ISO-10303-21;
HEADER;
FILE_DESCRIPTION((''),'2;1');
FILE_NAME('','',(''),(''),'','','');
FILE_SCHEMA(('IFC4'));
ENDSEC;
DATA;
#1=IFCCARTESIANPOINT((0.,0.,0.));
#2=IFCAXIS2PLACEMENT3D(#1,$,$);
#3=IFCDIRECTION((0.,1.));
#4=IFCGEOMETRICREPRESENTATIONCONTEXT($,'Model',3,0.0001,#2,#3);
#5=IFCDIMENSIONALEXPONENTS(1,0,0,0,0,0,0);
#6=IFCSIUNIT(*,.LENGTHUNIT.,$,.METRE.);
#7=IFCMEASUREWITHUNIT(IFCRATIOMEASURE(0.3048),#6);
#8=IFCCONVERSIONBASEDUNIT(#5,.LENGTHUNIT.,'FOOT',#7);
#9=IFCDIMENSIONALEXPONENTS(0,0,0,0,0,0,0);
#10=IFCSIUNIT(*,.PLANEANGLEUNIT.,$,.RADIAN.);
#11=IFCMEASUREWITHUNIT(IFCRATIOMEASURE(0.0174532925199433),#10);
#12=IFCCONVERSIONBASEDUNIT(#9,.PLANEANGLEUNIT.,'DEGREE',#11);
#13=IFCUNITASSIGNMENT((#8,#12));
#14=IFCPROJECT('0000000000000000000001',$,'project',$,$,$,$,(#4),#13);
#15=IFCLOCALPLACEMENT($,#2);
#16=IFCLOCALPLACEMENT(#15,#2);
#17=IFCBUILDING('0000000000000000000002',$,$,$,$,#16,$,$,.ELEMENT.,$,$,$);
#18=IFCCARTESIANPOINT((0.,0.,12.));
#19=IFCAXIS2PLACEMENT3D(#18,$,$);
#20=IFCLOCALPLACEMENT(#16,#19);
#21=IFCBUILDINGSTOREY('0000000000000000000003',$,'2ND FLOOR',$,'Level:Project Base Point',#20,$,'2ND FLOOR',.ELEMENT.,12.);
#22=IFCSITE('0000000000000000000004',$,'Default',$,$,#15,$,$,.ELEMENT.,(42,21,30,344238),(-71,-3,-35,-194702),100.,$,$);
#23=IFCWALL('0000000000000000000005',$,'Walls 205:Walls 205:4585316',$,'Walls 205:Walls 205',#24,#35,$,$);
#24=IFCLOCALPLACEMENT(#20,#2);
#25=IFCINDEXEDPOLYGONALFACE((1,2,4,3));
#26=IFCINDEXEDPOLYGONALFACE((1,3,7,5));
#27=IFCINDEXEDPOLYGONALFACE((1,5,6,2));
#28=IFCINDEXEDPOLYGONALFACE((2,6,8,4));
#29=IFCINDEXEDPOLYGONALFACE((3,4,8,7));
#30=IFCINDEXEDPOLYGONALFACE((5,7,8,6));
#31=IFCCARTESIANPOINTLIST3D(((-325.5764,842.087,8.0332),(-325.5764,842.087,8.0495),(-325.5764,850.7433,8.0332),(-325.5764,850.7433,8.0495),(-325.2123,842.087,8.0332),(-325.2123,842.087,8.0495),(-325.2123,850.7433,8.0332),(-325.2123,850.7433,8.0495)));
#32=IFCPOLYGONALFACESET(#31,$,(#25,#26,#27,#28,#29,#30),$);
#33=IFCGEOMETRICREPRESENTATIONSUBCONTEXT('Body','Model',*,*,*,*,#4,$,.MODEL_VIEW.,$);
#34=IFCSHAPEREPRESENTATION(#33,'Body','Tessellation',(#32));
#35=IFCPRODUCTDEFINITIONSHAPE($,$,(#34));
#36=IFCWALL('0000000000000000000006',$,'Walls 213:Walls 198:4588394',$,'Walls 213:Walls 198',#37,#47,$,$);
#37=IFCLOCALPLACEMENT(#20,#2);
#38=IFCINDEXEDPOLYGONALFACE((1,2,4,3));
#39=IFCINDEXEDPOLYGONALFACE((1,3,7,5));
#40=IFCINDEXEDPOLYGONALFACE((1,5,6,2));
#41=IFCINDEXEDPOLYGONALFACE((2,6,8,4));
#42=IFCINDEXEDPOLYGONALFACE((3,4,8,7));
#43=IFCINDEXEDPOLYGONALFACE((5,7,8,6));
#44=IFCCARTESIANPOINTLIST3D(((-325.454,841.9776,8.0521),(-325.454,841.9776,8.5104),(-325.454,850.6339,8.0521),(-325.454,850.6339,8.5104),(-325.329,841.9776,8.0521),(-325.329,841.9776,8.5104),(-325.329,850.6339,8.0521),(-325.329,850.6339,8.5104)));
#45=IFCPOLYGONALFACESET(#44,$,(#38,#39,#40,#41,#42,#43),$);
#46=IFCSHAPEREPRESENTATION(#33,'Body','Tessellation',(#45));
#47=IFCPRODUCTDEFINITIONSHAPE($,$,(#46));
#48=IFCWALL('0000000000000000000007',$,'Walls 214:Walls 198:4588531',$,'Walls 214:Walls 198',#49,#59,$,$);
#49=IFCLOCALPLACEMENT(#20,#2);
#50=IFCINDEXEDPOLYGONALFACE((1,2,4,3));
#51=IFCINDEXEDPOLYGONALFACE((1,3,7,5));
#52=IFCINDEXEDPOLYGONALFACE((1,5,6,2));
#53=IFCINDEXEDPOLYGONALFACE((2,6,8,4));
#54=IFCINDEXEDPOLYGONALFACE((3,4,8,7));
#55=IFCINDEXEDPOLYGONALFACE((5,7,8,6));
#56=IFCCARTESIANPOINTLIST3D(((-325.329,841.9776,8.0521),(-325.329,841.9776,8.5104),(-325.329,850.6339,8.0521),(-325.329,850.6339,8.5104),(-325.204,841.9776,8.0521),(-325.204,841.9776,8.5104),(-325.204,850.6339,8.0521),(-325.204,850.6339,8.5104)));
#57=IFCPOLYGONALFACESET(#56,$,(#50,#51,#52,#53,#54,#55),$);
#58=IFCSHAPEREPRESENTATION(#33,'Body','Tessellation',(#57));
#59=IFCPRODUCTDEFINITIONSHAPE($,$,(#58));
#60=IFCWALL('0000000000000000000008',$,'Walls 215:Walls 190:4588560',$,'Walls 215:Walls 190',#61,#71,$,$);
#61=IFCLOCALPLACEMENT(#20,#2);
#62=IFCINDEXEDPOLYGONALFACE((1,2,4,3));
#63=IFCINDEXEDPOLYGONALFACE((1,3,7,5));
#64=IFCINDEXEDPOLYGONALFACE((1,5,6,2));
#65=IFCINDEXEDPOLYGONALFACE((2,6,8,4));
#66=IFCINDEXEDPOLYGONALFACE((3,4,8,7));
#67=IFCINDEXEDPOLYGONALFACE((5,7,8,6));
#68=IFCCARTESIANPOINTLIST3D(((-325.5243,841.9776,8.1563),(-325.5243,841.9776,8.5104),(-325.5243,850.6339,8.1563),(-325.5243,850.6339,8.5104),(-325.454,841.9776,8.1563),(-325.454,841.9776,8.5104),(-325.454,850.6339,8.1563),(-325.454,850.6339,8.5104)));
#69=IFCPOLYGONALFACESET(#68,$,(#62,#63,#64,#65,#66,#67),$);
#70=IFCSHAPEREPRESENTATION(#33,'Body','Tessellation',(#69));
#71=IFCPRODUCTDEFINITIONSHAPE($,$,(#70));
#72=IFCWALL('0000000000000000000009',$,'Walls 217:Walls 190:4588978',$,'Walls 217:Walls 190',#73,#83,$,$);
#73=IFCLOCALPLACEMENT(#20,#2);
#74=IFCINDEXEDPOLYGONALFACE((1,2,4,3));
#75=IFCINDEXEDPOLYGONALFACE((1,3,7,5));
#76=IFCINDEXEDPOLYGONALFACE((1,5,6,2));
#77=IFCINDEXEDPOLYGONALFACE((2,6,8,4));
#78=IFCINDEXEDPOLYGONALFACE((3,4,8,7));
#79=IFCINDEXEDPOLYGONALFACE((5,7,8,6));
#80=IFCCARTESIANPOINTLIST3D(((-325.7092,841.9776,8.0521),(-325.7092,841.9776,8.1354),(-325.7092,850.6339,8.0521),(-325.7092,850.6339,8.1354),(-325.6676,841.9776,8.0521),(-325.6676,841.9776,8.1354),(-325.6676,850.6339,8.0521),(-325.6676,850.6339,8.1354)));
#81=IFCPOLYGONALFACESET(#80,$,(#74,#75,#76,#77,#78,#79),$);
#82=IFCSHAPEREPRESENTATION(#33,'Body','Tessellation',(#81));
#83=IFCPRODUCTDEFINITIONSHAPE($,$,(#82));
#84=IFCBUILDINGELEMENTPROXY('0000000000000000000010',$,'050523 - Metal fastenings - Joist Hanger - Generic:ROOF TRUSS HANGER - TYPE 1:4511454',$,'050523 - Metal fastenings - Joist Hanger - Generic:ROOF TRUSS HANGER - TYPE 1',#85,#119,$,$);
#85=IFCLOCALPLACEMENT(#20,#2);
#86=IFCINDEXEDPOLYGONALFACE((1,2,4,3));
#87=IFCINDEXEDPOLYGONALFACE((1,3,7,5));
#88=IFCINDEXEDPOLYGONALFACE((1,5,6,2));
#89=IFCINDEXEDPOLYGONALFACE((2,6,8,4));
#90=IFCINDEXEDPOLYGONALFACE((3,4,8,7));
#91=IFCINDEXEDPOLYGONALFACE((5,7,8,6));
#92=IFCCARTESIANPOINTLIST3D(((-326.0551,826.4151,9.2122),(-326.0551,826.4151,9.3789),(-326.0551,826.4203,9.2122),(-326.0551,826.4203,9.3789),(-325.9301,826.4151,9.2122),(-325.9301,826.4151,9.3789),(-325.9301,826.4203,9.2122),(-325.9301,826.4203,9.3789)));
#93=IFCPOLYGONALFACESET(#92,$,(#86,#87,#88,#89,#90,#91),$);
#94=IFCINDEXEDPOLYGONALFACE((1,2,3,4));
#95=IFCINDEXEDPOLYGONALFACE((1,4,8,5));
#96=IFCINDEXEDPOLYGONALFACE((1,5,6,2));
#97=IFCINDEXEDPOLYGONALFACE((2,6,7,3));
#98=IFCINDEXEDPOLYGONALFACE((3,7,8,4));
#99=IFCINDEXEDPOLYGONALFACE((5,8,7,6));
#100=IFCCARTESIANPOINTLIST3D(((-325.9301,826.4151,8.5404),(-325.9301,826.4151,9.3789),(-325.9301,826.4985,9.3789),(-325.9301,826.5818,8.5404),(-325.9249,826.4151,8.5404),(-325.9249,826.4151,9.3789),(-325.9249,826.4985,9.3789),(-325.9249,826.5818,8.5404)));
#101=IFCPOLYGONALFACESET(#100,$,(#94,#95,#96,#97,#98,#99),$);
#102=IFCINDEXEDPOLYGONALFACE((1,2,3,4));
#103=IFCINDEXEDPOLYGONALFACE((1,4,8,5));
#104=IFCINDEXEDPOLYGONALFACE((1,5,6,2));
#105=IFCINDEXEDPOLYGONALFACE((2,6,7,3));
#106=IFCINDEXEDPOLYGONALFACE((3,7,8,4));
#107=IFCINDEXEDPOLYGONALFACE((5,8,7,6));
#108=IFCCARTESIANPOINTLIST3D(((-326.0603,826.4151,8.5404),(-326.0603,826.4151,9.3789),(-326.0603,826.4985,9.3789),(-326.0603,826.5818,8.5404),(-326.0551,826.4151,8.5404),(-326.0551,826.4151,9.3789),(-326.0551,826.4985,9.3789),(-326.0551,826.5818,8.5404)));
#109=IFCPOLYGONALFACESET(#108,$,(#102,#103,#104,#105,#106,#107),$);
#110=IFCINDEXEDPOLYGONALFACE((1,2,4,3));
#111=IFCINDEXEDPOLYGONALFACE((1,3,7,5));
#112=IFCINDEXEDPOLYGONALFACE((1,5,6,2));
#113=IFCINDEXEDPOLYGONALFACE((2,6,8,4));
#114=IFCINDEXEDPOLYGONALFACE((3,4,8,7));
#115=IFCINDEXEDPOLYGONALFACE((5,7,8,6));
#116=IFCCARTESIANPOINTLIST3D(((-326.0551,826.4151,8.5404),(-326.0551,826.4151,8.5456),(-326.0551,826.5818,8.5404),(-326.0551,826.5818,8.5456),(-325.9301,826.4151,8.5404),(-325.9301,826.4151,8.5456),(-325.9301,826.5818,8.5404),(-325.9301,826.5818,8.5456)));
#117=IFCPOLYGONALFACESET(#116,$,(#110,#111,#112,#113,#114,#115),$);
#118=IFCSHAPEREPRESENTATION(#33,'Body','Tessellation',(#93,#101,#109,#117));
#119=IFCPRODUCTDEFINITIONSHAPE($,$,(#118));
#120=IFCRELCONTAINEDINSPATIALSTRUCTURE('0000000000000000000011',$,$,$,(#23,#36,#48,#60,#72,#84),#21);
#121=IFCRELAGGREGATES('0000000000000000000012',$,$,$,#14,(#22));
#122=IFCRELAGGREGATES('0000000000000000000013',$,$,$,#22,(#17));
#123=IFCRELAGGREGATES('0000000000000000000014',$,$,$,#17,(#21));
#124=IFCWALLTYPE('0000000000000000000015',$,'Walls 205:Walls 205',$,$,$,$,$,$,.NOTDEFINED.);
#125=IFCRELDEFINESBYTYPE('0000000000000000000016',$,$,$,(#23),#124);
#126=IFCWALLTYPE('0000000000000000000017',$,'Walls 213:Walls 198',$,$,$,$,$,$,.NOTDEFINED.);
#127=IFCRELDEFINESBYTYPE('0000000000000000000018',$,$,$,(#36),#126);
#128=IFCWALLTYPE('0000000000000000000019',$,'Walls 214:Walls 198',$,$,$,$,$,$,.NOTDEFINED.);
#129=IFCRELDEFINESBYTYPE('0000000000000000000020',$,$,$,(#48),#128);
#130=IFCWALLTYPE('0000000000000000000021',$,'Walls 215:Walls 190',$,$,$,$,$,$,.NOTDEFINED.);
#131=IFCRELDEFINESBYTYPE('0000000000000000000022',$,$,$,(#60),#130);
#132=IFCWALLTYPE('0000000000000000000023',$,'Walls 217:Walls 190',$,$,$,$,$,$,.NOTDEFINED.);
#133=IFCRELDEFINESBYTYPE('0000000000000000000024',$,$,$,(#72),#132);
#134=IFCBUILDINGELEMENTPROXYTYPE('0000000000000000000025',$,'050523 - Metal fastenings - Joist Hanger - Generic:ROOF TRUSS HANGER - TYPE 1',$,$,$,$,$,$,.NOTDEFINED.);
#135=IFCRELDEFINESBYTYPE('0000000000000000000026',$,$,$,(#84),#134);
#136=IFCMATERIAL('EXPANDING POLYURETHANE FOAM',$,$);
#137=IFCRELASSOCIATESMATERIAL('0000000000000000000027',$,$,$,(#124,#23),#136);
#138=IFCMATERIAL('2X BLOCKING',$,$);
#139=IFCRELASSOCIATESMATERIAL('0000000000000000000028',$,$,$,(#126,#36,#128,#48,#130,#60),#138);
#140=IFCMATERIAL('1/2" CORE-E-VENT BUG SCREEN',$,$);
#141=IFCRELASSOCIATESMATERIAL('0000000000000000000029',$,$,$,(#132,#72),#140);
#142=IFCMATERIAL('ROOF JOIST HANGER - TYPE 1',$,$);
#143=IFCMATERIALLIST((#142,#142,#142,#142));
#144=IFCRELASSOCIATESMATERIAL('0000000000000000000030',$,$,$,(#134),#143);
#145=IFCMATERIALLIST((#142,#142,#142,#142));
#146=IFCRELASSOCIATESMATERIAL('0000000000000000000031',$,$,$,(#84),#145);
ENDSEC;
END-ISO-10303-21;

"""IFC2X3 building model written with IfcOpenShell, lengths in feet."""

from ifc_helpers import new_model, entity, si_unit, converted_unit, direction, frame, frame_2d, origin, origin_2d_with_axis, place, context, subcontext, project, spatial, polyline, rectangle, outline, extrude, source, transform, mapped, material, material_list, type_object, type_shapes, element, save


model = new_model("IFC2X3")

# Units and contexts
model_context = context("Model", 3, precision=0.0001, world=origin(), true_north=direction((0.0, 1.0)))
body_context = subcontext(model_context, "Body", "Model", "MODEL_VIEW")
ifc_project = project(units=[converted_unit("LENGTHUNIT", "FOOT", entity("IfcRatioMeasure", 0.3048), si_unit("LENGTHUNIT", "METRE"), dimensions=[1, 0, 0, 0, 0, 0, 0]), converted_unit("PLANEANGLEUNIT", "DEGREE", entity("IfcRatioMeasure", 0.0174532925199433), si_unit("PLANEANGLEUNIT", "RADIAN"), dimensions=[0, 0, 0, 0, 0, 0, 0])], contexts=[model_context])

# Site, building, storey
site_placement = place(None, origin())
site = spatial("IfcSite", under=ifc_project, at=site_placement, Name="Default", CompositionType="ELEMENT", RefLatitude=(42, 21, 30, 344238), RefLongitude=(-71, -3, -35, -194702), RefElevation=100.0)
building_placement = place(site_placement, origin())
building = spatial("IfcBuilding", under=site, at=building_placement, CompositionType="ELEMENT")
storey_placement = place(building_placement, frame((0.0, 0.0, 12.0)))
storey = spatial("IfcBuildingStorey", under=building, at=storey_placement, Name="2ND FLOOR", ObjectType="Level:Project Base Point", LongName="2ND FLOOR", CompositionType="ELEMENT", Elevation=12.0)

# Shared definitions
ifc_material_1 = material(Name="EXPANDING POLYURETHANE FOAM")

# Walls
wall_type_1 = type_object("IfcWallType", Name="Walls 205:Walls 205", PredefinedType="NOTDEFINED", material=ifc_material_1)
wall_1_placement = place(storey_placement, frame((-325.5764, 842.087, 8.0332), z_axis=(0.0, 0.0, 1.0), x_axis=(0.0, 1.0, 0.0)))
element("IfcWall", 1, at=wall_1_placement, inside=storey, type_object=wall_type_1, material=ifc_material_1, Name="Walls 205:Walls 205:4585316", ObjectType="Walls 205:Walls 205", context=body_context, shape_type="SweptSolid", body=[
    extrude(rectangle(XDim=8.6563, YDim=0.3641, at=origin_2d_with_axis()), frame((4.3281, -0.182, 0.0), z_axis=(0.0, 0.0, 1.0), x_axis=(-1.0, 0.0, 0.0)), (0.0, 0.0, 1.0), 0.0163),
])
ifc_material_2 = material(Name="2X BLOCKING")
wall_type_2 = type_object("IfcWallType", Name="Walls 213:Walls 198", PredefinedType="NOTDEFINED", material=ifc_material_2)
wall_2_placement = place(storey_placement, frame((-325.454, 841.9776, 8.0521), z_axis=(0.0, 0.0, 1.0), x_axis=(0.0, 1.0, 0.0)))
element("IfcWall", 2, at=wall_2_placement, inside=storey, type_object=wall_type_2, material=ifc_material_2, Name="Walls 213:Walls 198:4588394", ObjectType="Walls 213:Walls 198", context=body_context, shape_type="SweptSolid", body=[
    extrude(rectangle(XDim=8.6563, YDim=0.125, at=frame_2d((0.0, 0.0), x_axis=(1.0, 0.0))), frame((4.3281, -0.0625, 0.0), z_axis=(0.0, 0.0, 1.0), x_axis=(-1.0, 0.0, 0.0)), (0.0, 0.0, 1.0), 0.4583),
])
wall_type_3 = type_object("IfcWallType", Name="Walls 214:Walls 198", PredefinedType="NOTDEFINED", material=ifc_material_2)
wall_3_placement = place(storey_placement, frame((-325.329, 841.9776, 8.0521), z_axis=(0.0, 0.0, 1.0), x_axis=(0.0, 1.0, 0.0)))
element("IfcWall", 3, at=wall_3_placement, inside=storey, type_object=wall_type_3, material=ifc_material_2, Name="Walls 214:Walls 198:4588531", ObjectType="Walls 214:Walls 198", context=body_context, shape_type="SweptSolid", body=[
    extrude(rectangle(XDim=8.6563, YDim=0.125, at=frame_2d((0.0, 0.0), x_axis=(1.0, 0.0))), frame((4.3281, -0.0625, 0.0), z_axis=(0.0, 0.0, 1.0), x_axis=(-1.0, 0.0, 0.0)), (0.0, 0.0, 1.0), 0.4583),
])
wall_type_4 = type_object("IfcWallType", Name="Walls 215:Walls 190", PredefinedType="NOTDEFINED", material=ifc_material_2)
wall_4_placement = place(storey_placement, frame((-325.5243, 841.9776, 8.1563), z_axis=(0.0, 0.0, 1.0), x_axis=(0.0, 1.0, 0.0)))
element("IfcWall", 4, at=wall_4_placement, inside=storey, type_object=wall_type_4, material=ifc_material_2, Name="Walls 215:Walls 190:4588560", ObjectType="Walls 215:Walls 190", context=body_context, shape_type="SweptSolid", body=[
    extrude(rectangle(XDim=8.6563, YDim=0.0703, at=origin_2d_with_axis()), frame((4.3281, -0.0352, 0.0), z_axis=(0.0, 0.0, 1.0), x_axis=(-1.0, 0.0, 0.0)), (0.0, 0.0, 1.0), 0.3542),
])
ifc_material_3 = material(Name="1/2\" CORE-E-VENT BUG SCREEN")
wall_type_5 = type_object("IfcWallType", Name="Walls 217:Walls 190", PredefinedType="NOTDEFINED", material=ifc_material_3)
wall_5_placement = place(storey_placement, frame((-325.7092, 841.9776, 8.0521), z_axis=(0.0, 0.0, 1.0), x_axis=(0.0, 1.0, 0.0)))
element("IfcWall", 5, at=wall_5_placement, inside=storey, type_object=wall_type_5, material=ifc_material_3, Name="Walls 217:Walls 190:4588978", ObjectType="Walls 217:Walls 190", context=body_context, shape_type="SweptSolid", body=[
    extrude(rectangle(XDim=8.6563, YDim=0.0417, at=origin_2d_with_axis()), frame((4.3281, -0.0208, 0.0), z_axis=(0.0, 0.0, 1.0), x_axis=(-1.0, 0.0, 0.0)), (0.0, 0.0, 1.0), 0.0833),
])

# Building element proxy
ifc_material_4 = material(Name="ROOF JOIST HANGER - TYPE 1")
ifc_material_list_1 = material_list([ifc_material_4, ifc_material_4, ifc_material_4, ifc_material_4])
ifc_material_list_2 = material_list([ifc_material_4, ifc_material_4, ifc_material_4, ifc_material_4])
building_element_proxy_type = type_object("IfcBuildingElementProxyType", Name="050523 - Metal fastenings - Joist Hanger - Generic:ROOF TRUSS HANGER - TYPE 1", PredefinedType="NOTDEFINED", material=ifc_material_list_2)
shared_shape = source(origin(), body_context, "Body", "SweptSolid", [
    extrude(rectangle(XDim=0.0052, YDim=0.125, at=origin_2d_with_axis()), frame((0.0, -0.0026, 0.6667), z_axis=(0.0, 0.0, 1.0), x_axis=(0.0, 1.0, 0.0)), (0.0, 0.0, 1.0), 0.1667),
    extrude(outline(polyline([(-0.4193, -0.0625), (0.4193, -0.0625), (0.4193, 0.0208), (-0.4193, 0.1042), (-0.4193, -0.0625)])), frame((-0.0677, -0.0625, 0.4141), z_axis=(1.0, 0.0, 0.0), x_axis=(0.0, 0.0, 1.0)), (0.0, 0.0, 1.0), 0.0052),
    extrude(outline(polyline([(-0.4193, -0.0625), (0.4193, -0.0625), (0.4193, 0.0208), (-0.4193, 0.1042), (-0.4193, -0.0625)])), frame((0.0625, -0.0625, 0.4141), z_axis=(1.0, 0.0, 0.0), x_axis=(0.0, 0.0, 1.0)), (0.0, 0.0, 1.0), 0.0052),
    extrude(rectangle(XDim=0.1667, YDim=0.125, at=frame_2d((0.0, 0.0), x_axis=(1.0, 0.0))), frame((0.0, -0.0833, -0.0052), z_axis=(0.0, 0.0, 1.0), x_axis=(0.0, -1.0, 0.0)), (0.0, 0.0, 1.0), 0.0052),
])
type_shapes(building_element_proxy_type, [shared_shape])
proxy_placement = place(storey_placement, frame((-325.9926, 826.4151, 8.5456), z_axis=(0.0, 0.0, 1.0), x_axis=(-1.0, 0.0, 0.0)))
element("IfcBuildingElementProxy", 6, at=proxy_placement, inside=storey, type_object=building_element_proxy_type, material=ifc_material_list_1, Name="050523 - Metal fastenings - Joist Hanger - Generic:ROOF TRUSS HANGER - TYPE 1:4511454", ObjectType="050523 - Metal fastenings - Joist Hanger - Generic:ROOF TRUSS HANGER - TYPE 1", context=body_context, shape_type="MappedRepresentation", body=[
    mapped(shared_shape, transform((0.0, 0.0, 0.0), scale=1.0)),
])

save(model, "model.ifc")
